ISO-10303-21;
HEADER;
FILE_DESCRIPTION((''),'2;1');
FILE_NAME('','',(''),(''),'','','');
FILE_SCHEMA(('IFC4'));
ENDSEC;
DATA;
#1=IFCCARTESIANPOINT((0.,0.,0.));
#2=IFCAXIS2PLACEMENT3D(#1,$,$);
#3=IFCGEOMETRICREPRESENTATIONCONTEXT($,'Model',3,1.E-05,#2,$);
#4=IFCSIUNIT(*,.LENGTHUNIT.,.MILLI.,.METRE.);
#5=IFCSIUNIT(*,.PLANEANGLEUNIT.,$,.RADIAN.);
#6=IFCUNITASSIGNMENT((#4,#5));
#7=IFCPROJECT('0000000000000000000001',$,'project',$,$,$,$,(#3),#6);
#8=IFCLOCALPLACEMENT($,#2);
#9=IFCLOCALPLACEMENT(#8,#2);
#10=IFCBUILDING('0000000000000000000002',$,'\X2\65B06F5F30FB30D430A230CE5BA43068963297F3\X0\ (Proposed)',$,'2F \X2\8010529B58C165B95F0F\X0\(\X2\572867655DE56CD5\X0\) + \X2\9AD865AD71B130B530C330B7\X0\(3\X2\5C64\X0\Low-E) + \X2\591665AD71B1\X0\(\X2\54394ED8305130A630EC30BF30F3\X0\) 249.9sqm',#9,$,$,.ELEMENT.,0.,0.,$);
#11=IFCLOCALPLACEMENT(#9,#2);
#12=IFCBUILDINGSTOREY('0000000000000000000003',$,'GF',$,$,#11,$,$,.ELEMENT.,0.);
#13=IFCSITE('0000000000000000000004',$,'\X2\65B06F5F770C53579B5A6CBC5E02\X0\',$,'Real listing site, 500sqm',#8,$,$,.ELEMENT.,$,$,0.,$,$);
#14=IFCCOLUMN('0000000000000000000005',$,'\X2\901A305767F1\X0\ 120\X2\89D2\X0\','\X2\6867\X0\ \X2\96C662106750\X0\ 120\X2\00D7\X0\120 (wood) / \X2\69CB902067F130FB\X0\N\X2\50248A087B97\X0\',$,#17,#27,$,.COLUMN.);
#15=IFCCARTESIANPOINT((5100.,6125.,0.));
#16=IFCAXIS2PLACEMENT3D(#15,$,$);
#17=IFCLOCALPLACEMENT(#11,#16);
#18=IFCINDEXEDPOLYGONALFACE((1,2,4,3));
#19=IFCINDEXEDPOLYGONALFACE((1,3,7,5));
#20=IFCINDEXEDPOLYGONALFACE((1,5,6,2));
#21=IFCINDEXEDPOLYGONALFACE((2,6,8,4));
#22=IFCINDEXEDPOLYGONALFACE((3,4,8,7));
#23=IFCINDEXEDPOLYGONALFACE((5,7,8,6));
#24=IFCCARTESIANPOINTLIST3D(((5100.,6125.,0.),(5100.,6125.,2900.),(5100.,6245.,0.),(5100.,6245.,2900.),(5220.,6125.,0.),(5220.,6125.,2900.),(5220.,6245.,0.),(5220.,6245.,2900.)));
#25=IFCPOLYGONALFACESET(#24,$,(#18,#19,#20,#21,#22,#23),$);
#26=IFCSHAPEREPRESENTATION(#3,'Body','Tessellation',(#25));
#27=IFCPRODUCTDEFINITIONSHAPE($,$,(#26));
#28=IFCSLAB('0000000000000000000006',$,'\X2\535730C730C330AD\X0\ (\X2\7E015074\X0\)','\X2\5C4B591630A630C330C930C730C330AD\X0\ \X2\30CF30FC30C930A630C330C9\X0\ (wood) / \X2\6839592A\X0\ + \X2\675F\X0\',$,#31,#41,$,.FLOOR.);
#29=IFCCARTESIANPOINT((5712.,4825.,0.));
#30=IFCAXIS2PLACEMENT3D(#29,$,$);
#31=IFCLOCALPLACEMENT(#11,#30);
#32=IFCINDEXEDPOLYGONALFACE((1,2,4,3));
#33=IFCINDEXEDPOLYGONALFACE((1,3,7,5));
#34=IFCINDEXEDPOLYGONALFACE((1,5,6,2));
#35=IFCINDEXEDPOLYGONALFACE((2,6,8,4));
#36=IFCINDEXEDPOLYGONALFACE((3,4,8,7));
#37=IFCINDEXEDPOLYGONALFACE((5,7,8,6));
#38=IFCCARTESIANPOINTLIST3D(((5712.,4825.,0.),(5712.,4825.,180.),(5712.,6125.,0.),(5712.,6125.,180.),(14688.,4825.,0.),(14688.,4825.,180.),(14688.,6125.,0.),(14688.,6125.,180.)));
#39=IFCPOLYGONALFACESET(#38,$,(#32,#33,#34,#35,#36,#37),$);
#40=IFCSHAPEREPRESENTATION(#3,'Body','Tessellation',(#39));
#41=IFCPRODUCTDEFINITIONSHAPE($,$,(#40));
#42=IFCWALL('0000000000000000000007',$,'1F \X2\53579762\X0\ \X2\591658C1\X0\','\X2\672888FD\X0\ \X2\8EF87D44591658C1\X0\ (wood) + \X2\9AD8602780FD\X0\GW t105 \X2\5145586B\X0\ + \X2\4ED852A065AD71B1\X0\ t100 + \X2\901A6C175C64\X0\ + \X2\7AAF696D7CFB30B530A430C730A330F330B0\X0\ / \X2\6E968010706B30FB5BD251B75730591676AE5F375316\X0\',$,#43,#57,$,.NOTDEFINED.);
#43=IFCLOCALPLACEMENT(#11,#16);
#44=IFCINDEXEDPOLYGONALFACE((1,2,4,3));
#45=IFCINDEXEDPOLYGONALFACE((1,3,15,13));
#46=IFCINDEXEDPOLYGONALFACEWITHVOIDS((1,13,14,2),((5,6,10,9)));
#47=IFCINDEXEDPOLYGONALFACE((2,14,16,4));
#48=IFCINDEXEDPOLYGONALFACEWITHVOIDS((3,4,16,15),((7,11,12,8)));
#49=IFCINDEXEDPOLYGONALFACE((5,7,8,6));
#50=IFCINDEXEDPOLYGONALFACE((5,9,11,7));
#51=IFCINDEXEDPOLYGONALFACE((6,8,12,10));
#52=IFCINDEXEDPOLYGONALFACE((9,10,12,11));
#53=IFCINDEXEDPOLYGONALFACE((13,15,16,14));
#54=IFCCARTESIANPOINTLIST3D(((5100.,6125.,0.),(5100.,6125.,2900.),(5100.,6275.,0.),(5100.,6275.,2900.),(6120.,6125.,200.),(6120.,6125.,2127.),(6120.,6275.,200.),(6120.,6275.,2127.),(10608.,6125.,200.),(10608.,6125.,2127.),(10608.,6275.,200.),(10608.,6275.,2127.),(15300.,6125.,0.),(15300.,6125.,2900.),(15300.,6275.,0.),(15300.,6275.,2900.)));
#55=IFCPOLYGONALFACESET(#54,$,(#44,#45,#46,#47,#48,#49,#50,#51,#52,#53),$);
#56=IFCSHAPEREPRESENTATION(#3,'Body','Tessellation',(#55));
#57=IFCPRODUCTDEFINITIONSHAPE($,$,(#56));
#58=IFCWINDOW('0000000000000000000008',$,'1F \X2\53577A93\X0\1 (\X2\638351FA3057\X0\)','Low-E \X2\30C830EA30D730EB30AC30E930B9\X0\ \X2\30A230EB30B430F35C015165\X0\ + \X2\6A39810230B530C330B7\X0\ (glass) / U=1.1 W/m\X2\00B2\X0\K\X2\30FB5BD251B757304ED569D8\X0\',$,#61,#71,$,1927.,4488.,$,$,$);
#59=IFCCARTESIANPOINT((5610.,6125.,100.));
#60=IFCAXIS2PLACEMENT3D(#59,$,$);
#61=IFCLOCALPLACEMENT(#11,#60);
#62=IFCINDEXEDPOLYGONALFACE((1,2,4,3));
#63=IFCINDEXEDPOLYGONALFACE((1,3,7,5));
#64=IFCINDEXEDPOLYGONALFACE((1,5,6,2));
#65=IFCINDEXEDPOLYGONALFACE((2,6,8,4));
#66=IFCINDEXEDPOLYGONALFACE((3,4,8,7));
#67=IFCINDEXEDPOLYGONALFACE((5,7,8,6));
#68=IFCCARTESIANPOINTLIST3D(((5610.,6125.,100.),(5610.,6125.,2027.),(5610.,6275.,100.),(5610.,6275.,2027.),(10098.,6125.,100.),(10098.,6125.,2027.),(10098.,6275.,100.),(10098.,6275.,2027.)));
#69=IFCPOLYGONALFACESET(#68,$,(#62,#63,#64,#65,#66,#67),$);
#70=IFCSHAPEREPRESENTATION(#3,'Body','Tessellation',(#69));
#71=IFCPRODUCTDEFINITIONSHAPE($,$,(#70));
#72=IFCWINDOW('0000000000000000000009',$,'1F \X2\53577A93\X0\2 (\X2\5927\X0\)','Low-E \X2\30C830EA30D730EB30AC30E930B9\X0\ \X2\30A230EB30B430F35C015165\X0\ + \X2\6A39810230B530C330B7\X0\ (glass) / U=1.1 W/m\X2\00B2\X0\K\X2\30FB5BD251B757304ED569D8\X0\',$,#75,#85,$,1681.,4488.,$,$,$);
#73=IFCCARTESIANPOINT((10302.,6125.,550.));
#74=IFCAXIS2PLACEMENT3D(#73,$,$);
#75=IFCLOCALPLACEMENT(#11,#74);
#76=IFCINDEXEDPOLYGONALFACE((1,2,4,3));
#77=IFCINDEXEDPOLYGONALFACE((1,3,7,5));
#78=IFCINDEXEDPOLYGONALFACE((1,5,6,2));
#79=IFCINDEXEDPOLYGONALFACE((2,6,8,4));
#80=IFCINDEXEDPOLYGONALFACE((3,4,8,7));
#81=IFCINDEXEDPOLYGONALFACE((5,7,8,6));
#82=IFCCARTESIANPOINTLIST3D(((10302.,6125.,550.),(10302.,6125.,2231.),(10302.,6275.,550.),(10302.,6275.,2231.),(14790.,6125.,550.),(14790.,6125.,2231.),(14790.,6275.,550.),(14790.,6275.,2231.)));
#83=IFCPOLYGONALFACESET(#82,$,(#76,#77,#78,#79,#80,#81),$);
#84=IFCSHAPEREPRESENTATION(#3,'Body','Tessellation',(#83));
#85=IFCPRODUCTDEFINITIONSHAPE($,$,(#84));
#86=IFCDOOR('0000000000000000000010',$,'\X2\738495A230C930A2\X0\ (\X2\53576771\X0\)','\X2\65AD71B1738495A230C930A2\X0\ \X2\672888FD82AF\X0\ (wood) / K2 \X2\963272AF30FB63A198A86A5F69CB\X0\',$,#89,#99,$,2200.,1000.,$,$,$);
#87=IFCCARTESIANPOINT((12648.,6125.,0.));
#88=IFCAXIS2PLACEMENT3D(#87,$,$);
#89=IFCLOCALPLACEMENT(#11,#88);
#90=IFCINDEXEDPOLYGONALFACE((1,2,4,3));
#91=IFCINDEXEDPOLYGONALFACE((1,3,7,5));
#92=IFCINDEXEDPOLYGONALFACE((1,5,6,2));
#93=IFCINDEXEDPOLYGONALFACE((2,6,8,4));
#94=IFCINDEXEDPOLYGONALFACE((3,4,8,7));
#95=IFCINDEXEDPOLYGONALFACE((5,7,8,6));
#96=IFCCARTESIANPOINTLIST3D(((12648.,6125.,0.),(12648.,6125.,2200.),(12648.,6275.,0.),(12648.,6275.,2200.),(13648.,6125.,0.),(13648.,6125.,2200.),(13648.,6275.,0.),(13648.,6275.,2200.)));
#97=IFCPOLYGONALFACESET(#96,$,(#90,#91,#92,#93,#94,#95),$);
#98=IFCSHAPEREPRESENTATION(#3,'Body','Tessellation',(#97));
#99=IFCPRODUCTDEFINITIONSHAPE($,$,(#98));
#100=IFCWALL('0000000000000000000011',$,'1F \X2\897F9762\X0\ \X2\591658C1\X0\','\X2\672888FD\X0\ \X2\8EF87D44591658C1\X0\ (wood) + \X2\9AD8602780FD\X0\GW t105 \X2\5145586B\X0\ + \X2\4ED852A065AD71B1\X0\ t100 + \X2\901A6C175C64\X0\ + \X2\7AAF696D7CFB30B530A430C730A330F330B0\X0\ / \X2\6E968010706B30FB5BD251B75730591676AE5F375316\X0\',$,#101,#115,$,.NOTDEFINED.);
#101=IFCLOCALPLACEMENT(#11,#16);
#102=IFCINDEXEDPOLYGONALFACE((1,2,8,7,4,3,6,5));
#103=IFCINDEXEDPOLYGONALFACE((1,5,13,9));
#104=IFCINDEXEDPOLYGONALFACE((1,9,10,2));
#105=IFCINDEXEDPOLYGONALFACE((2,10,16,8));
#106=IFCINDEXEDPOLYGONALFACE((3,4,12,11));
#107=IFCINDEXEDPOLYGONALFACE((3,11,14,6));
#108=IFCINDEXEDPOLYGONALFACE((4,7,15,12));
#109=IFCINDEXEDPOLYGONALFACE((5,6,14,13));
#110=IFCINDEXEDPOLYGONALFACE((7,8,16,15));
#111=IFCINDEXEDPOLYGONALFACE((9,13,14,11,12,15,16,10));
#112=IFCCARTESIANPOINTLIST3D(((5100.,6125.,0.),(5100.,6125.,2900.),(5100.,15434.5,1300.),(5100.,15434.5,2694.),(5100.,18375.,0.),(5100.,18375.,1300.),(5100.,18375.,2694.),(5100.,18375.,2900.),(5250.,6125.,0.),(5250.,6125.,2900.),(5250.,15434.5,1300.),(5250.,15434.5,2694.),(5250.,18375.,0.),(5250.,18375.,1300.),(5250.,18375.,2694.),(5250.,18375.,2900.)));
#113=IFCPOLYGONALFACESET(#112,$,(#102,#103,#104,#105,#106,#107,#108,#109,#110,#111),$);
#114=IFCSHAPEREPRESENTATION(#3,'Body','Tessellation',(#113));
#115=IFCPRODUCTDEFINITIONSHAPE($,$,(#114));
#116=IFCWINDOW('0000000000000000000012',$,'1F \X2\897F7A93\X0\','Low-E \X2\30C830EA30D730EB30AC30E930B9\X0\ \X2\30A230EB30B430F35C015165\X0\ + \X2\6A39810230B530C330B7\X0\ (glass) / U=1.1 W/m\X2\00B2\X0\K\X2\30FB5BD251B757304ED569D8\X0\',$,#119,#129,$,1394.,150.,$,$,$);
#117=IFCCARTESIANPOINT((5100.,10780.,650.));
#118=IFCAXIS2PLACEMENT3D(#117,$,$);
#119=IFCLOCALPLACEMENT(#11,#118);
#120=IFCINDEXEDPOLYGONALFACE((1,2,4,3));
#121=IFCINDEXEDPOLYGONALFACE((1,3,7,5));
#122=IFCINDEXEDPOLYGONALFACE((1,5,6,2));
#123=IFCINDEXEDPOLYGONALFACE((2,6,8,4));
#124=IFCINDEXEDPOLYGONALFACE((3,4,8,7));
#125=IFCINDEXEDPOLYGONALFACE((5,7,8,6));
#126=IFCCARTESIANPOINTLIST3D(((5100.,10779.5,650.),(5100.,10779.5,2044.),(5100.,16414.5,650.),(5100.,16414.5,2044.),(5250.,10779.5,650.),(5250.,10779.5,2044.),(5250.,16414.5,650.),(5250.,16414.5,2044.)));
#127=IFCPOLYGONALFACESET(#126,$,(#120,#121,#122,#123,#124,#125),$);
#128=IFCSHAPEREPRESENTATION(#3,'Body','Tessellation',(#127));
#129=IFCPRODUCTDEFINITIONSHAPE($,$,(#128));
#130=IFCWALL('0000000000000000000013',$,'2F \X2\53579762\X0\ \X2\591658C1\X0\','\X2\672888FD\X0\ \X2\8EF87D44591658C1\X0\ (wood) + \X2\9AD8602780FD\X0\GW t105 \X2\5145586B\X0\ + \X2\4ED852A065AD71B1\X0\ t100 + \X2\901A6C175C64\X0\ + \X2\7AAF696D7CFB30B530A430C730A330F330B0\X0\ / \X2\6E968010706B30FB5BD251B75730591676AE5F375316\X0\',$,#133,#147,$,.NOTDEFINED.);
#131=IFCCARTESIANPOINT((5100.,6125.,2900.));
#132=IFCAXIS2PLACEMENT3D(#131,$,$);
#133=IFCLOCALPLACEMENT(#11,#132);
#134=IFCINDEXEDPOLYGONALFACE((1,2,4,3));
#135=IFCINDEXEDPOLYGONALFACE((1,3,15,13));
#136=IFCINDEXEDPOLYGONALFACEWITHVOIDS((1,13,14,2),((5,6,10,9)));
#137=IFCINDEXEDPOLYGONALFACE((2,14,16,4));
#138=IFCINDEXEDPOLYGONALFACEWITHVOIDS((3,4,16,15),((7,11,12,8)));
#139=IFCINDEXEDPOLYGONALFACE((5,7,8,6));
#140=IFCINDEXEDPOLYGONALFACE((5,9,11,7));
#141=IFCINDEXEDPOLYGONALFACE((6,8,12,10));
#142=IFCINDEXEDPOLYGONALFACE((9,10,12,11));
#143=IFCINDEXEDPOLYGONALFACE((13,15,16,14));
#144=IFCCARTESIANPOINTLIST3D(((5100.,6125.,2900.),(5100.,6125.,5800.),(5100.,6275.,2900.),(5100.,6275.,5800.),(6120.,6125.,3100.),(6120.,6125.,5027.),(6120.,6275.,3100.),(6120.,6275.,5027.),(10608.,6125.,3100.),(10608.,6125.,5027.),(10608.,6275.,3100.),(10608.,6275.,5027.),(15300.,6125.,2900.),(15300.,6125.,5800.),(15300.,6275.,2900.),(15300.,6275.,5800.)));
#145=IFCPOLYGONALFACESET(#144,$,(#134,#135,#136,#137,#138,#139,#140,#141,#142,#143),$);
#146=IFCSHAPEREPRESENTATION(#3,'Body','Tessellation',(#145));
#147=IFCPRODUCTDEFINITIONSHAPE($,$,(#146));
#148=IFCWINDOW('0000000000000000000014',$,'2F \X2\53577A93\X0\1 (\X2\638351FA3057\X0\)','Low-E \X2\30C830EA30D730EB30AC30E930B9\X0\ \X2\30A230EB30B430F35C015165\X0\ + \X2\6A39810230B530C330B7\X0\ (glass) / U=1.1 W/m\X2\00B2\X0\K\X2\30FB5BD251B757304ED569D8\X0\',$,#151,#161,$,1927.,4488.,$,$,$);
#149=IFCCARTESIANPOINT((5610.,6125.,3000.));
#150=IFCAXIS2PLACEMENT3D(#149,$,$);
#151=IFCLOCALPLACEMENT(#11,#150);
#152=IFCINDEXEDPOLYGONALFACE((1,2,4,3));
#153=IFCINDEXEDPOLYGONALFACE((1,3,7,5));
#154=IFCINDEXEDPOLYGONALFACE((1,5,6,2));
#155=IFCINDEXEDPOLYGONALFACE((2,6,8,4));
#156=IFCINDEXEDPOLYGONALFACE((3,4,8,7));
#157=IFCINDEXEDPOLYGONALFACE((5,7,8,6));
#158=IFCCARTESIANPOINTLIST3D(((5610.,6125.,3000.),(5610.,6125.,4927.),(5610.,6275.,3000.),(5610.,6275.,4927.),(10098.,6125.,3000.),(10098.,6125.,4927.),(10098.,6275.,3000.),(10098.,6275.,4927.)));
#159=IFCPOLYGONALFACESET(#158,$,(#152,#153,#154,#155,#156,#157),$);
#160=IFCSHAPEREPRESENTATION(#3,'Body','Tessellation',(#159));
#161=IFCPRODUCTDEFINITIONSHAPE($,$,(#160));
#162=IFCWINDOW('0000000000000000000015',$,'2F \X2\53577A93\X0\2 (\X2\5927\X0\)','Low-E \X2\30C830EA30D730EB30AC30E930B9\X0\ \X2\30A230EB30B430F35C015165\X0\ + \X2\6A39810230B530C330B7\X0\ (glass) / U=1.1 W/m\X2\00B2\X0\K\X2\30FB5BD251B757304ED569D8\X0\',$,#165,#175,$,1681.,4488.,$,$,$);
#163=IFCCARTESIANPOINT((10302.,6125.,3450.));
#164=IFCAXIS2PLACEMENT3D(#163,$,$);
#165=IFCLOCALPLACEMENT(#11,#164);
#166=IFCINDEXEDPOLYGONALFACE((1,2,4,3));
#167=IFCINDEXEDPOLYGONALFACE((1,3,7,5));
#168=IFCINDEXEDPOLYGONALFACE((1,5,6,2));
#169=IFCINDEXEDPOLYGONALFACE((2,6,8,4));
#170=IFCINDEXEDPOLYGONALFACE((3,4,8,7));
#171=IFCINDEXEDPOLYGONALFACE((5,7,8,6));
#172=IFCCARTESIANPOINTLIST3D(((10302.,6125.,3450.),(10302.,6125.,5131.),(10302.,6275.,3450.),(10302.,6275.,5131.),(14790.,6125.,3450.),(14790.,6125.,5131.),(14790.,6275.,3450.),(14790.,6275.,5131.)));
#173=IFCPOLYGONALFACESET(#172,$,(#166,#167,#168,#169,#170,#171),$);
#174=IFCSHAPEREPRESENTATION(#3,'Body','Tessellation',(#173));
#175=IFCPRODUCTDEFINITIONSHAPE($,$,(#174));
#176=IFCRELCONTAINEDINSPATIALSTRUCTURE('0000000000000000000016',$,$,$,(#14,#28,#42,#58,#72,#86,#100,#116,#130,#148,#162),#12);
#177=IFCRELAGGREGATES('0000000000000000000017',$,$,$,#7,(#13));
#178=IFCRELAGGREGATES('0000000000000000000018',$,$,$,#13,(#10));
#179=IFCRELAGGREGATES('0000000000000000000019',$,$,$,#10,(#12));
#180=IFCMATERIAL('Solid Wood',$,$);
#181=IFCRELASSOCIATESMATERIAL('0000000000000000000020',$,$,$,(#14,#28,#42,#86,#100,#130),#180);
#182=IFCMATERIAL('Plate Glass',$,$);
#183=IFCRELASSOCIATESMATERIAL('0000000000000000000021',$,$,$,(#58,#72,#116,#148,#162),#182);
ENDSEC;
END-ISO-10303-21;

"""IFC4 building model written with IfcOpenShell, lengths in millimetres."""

from ifc_helpers import new_model, si_unit, frame, frame_2d, origin, place, context, project, spatial, rectangle, extrude, material, element, fill, save


model = new_model("IFC4")

# Units and contexts
model_context = context("Model", 3, precision=1e-05, world=origin())
ifc_project = project(units=[si_unit("LENGTHUNIT", "METRE", prefix="MILLI"), si_unit("PLANEANGLEUNIT", "RADIAN")], contexts=[model_context])

# Site, building, storey
site_placement = place(None, origin())
site = spatial("IfcSite", under=ifc_project, at=site_placement, Name="新潟県南魚沼市", ObjectType="Real listing site, 500sqm", CompositionType="ELEMENT", RefElevation=0.0)
building_placement = place(site_placement, origin())
building = spatial("IfcBuilding", under=site, at=building_placement, Name="新潟・ピアノ室と防音 (Proposed)", ObjectType="2F 耐力壁方式(在来工法) + 高断熱サッシ(3層Low-E) + 外断熱(吹付けウレタン) 249.9sqm", CompositionType="ELEMENT", ElevationOfRefHeight=0.0, ElevationOfTerrain=0.0)
storey_placement = place(building_placement, origin())
storey = spatial("IfcBuildingStorey", under=building, at=storey_placement, Name="GF", CompositionType="ELEMENT", Elevation=0.0)

# Column
ifc_material_1 = material(Name="Solid Wood")
column_placement = place(storey_placement, frame((5100.0, 6125.0, 0.0)))
element("IfcColumn", 1, at=column_placement, inside=storey, material=ifc_material_1, Name="通し柱 120角", Description="桧 集成材 120×120 (wood) / 構造柱・N値計算", PredefinedType="COLUMN", context=model_context, shape_type="SweptSolid", body=[
    extrude(rectangle(XDim=120.0, YDim=120.0, at=frame_2d((60.0, 60.0))), frame((5100.0, 6125.0, 0.0)), (0.0, 0.0, 1.0), 2900.0),
])

# Slab
slab_1_placement = place(storey_placement, frame((5712.0, 4825.0, 0.0)))
element("IfcSlab", 2, at=slab_1_placement, inside=storey, material=ifc_material_1, Name="南デッキ (縁側)", Description="屋外ウッドデッキ ハードウッド (wood) / 根太 + 束", PredefinedType="FLOOR", context=model_context, shape_type="SweptSolid", body=[
    extrude(rectangle(XDim=8976.0, YDim=1300.0, at=frame_2d((4488.0, 650.0))), frame((5712.0, 4825.0, 0.0)), (0.0, 0.0, 1.0), 180.0),
])

# Wall, openings, windows, door
wall_1_placement = place(storey_placement, frame((5100.0, 6125.0, 0.0)))
wall_1 = element("IfcWall", 3, at=wall_1_placement, inside=storey, material=ifc_material_1, Name="1F 南面 外壁", Description="木製 軸組外壁 (wood) + 高性能GW t105 充填 + 付加断熱 t100 + 通気層 + 窯業系サイディング / 準耐火・寒冷地外皮強化", PredefinedType="NOTDEFINED", context=model_context, shape_type="SweptSolid", body=[
    extrude(rectangle(XDim=10200.0, YDim=150.0, at=frame_2d((5100.0, 75.0))), frame((5100.0, 6125.0, 0.0)), (0.0, 0.0, 1.0), 2900.0),
])
opening_1_placement = place(storey_placement, frame((5610.0, 6125.0, 100.0)))
opening_1 = element("IfcOpeningElement", 4, at=opening_1_placement, cuts=wall_1, PredefinedType="NOTDEFINED", context=model_context, shape_type="SweptSolid", body=[
    extrude(rectangle(XDim=4488.0, YDim=150.0, at=frame_2d((2244.0, 75.0))), frame((5610.0, 6125.0, 100.0)), (0.0, 0.0, 1.0), 1927.0),
])
opening_2_placement = place(storey_placement, frame((10302.0, 6125.0, 550.0)))
opening_2 = element("IfcOpeningElement", 5, at=opening_2_placement, cuts=wall_1, PredefinedType="NOTDEFINED", context=model_context, shape_type="SweptSolid", body=[
    extrude(rectangle(XDim=4488.0, YDim=150.0, at=frame_2d((2244.0, 75.0))), frame((10302.0, 6125.0, 550.0)), (0.0, 0.0, 1.0), 1681.0),
])
opening_3_placement = place(storey_placement, frame((12648.0, 6125.0, 0.0)))
opening_3 = element("IfcOpeningElement", 6, at=opening_3_placement, cuts=wall_1, PredefinedType="NOTDEFINED", context=model_context, shape_type="SweptSolid", body=[
    extrude(rectangle(XDim=1000.0, YDim=150.0, at=frame_2d((500.0, 75.0))), frame((12648.0, 6125.0, 0.0)), (0.0, 0.0, 1.0), 2200.0),
])
ifc_material_2 = material(Name="Plate Glass")
window_1_placement = place(storey_placement, frame((5610.0, 6125.0, 100.0)))
window_1 = element("IfcWindow", 7, at=window_1_placement, inside=storey, material=ifc_material_2, Name="1F 南窓1 (掃出し)", Description="Low-E トリプルガラス アルゴン封入 + 樹脂サッシ (glass) / U=1.1 W/m²K・寒冷地仕様", OverallHeight=1927.0, OverallWidth=4488.0, context=model_context, shape_type="SweptSolid", body=[
    extrude(rectangle(XDim=4488.0, YDim=150.0, at=frame_2d((2244.0, 75.0))), frame((5610.0, 6125.0, 100.0)), (0.0, 0.0, 1.0), 1927.0),
])
fill(opening_1, window_1)
window_2_placement = place(storey_placement, frame((10302.0, 6125.0, 550.0)))
window_2 = element("IfcWindow", 8, at=window_2_placement, inside=storey, material=ifc_material_2, Name="1F 南窓2 (大)", Description="Low-E トリプルガラス アルゴン封入 + 樹脂サッシ (glass) / U=1.1 W/m²K・寒冷地仕様", OverallHeight=1681.0, OverallWidth=4488.0, context=model_context, shape_type="SweptSolid", body=[
    extrude(rectangle(XDim=4488.0, YDim=150.0, at=frame_2d((2244.0, 75.0))), frame((10302.0, 6125.0, 550.0)), (0.0, 0.0, 1.0), 1681.0),
])
fill(opening_2, window_2)
door_placement = place(storey_placement, frame((12648.0, 6125.0, 0.0)))
door = element("IfcDoor", 9, at=door_placement, inside=storey, material=ifc_material_1, Name="玄関ドア (南東)", Description="断熱玄関ドア 木製芯 (wood) / K2 防犯・採風機構", OverallHeight=2200.0, OverallWidth=1000.0, context=model_context, shape_type="SweptSolid", body=[
    extrude(rectangle(XDim=1000.0, YDim=150.0, at=frame_2d((500.0, 75.0))), frame((12648.0, 6125.0, 0.0)), (0.0, 0.0, 1.0), 2200.0),
])
fill(opening_3, door)

# Wall, opening, window
wall_2_placement = place(storey_placement, frame((5100.0, 6125.0, 0.0)))
wall_2 = element("IfcWall", 10, at=wall_2_placement, inside=storey, material=ifc_material_1, Name="1F 西面 外壁", Description="木製 軸組外壁 (wood) + 高性能GW t105 充填 + 付加断熱 t100 + 通気層 + 窯業系サイディング / 準耐火・寒冷地外皮強化", PredefinedType="NOTDEFINED", context=model_context, shape_type="SweptSolid", body=[
    extrude(rectangle(XDim=150.0, YDim=12250.0, at=frame_2d((75.0, 6125.0))), frame((5100.0, 6125.0, 0.0)), (0.0, 0.0, 1.0), 2900.0),
])
opening_4_placement = place(storey_placement, frame((5100.0, 10780.0, 650.0)))
opening_4 = element("IfcOpeningElement", 11, at=opening_4_placement, cuts=wall_2, PredefinedType="NOTDEFINED", context=model_context, shape_type="SweptSolid", body=[
    extrude(rectangle(XDim=150.0, YDim=5635.0, at=frame_2d((75.0, 2817.0))), frame((5100.0, 10780.0, 650.0)), (0.0, 0.0, 1.0), 1394.0),
])
window_3_placement = place(storey_placement, frame((5100.0, 10780.0, 650.0)))
window_3 = element("IfcWindow", 12, at=window_3_placement, inside=storey, material=ifc_material_2, Name="1F 西窓", Description="Low-E トリプルガラス アルゴン封入 + 樹脂サッシ (glass) / U=1.1 W/m²K・寒冷地仕様", OverallHeight=1394.0, OverallWidth=150.0, context=model_context, shape_type="SweptSolid", body=[
    extrude(rectangle(XDim=150.0, YDim=5635.0, at=frame_2d((75.0, 2817.0))), frame((5100.0, 10780.0, 650.0)), (0.0, 0.0, 1.0), 1394.0),
])
fill(opening_4, window_3)

# Wall, openings, windows
wall_3_placement = place(storey_placement, frame((5100.0, 6125.0, 2900.0)))
wall_3 = element("IfcWall", 13, at=wall_3_placement, inside=storey, material=ifc_material_1, Name="2F 南面 外壁", Description="木製 軸組外壁 (wood) + 高性能GW t105 充填 + 付加断熱 t100 + 通気層 + 窯業系サイディング / 準耐火・寒冷地外皮強化", PredefinedType="NOTDEFINED", context=model_context, shape_type="SweptSolid", body=[
    extrude(rectangle(XDim=10200.0, YDim=150.0, at=frame_2d((5100.0, 75.0))), frame((5100.0, 6125.0, 2900.0)), (0.0, 0.0, 1.0), 2900.0),
])
opening_5_placement = place(storey_placement, frame((5610.0, 6125.0, 3000.0)))
opening_5 = element("IfcOpeningElement", 14, at=opening_5_placement, cuts=wall_3, PredefinedType="NOTDEFINED", context=model_context, shape_type="SweptSolid", body=[
    extrude(rectangle(XDim=4488.0, YDim=150.0, at=frame_2d((2244.0, 75.0))), frame((5610.0, 6125.0, 3000.0)), (0.0, 0.0, 1.0), 1927.0),
])
opening_6_placement = place(storey_placement, frame((10302.0, 6125.0, 3450.0)))
opening_6 = element("IfcOpeningElement", 15, at=opening_6_placement, cuts=wall_3, PredefinedType="NOTDEFINED", context=model_context, shape_type="SweptSolid", body=[
    extrude(rectangle(XDim=4488.0, YDim=150.0, at=frame_2d((2244.0, 75.0))), frame((10302.0, 6125.0, 3450.0)), (0.0, 0.0, 1.0), 1681.0),
])
window_4_placement = place(storey_placement, frame((5610.0, 6125.0, 3000.0)))
window_4 = element("IfcWindow", 16, at=window_4_placement, inside=storey, material=ifc_material_2, Name="2F 南窓1 (掃出し)", Description="Low-E トリプルガラス アルゴン封入 + 樹脂サッシ (glass) / U=1.1 W/m²K・寒冷地仕様", OverallHeight=1927.0, OverallWidth=4488.0, context=model_context, shape_type="SweptSolid", body=[
    extrude(rectangle(XDim=4488.0, YDim=150.0, at=frame_2d((2244.0, 75.0))), frame((5610.0, 6125.0, 3000.0)), (0.0, 0.0, 1.0), 1927.0),
])
fill(opening_5, window_4)
window_5_placement = place(storey_placement, frame((10302.0, 6125.0, 3450.0)))
window_5 = element("IfcWindow", 17, at=window_5_placement, inside=storey, material=ifc_material_2, Name="2F 南窓2 (大)", Description="Low-E トリプルガラス アルゴン封入 + 樹脂サッシ (glass) / U=1.1 W/m²K・寒冷地仕様", OverallHeight=1681.0, OverallWidth=4488.0, context=model_context, shape_type="SweptSolid", body=[
    extrude(rectangle(XDim=4488.0, YDim=150.0, at=frame_2d((2244.0, 75.0))), frame((10302.0, 6125.0, 3450.0)), (0.0, 0.0, 1.0), 1681.0),
])
fill(opening_6, window_5)

save(model, "model.ifc")
